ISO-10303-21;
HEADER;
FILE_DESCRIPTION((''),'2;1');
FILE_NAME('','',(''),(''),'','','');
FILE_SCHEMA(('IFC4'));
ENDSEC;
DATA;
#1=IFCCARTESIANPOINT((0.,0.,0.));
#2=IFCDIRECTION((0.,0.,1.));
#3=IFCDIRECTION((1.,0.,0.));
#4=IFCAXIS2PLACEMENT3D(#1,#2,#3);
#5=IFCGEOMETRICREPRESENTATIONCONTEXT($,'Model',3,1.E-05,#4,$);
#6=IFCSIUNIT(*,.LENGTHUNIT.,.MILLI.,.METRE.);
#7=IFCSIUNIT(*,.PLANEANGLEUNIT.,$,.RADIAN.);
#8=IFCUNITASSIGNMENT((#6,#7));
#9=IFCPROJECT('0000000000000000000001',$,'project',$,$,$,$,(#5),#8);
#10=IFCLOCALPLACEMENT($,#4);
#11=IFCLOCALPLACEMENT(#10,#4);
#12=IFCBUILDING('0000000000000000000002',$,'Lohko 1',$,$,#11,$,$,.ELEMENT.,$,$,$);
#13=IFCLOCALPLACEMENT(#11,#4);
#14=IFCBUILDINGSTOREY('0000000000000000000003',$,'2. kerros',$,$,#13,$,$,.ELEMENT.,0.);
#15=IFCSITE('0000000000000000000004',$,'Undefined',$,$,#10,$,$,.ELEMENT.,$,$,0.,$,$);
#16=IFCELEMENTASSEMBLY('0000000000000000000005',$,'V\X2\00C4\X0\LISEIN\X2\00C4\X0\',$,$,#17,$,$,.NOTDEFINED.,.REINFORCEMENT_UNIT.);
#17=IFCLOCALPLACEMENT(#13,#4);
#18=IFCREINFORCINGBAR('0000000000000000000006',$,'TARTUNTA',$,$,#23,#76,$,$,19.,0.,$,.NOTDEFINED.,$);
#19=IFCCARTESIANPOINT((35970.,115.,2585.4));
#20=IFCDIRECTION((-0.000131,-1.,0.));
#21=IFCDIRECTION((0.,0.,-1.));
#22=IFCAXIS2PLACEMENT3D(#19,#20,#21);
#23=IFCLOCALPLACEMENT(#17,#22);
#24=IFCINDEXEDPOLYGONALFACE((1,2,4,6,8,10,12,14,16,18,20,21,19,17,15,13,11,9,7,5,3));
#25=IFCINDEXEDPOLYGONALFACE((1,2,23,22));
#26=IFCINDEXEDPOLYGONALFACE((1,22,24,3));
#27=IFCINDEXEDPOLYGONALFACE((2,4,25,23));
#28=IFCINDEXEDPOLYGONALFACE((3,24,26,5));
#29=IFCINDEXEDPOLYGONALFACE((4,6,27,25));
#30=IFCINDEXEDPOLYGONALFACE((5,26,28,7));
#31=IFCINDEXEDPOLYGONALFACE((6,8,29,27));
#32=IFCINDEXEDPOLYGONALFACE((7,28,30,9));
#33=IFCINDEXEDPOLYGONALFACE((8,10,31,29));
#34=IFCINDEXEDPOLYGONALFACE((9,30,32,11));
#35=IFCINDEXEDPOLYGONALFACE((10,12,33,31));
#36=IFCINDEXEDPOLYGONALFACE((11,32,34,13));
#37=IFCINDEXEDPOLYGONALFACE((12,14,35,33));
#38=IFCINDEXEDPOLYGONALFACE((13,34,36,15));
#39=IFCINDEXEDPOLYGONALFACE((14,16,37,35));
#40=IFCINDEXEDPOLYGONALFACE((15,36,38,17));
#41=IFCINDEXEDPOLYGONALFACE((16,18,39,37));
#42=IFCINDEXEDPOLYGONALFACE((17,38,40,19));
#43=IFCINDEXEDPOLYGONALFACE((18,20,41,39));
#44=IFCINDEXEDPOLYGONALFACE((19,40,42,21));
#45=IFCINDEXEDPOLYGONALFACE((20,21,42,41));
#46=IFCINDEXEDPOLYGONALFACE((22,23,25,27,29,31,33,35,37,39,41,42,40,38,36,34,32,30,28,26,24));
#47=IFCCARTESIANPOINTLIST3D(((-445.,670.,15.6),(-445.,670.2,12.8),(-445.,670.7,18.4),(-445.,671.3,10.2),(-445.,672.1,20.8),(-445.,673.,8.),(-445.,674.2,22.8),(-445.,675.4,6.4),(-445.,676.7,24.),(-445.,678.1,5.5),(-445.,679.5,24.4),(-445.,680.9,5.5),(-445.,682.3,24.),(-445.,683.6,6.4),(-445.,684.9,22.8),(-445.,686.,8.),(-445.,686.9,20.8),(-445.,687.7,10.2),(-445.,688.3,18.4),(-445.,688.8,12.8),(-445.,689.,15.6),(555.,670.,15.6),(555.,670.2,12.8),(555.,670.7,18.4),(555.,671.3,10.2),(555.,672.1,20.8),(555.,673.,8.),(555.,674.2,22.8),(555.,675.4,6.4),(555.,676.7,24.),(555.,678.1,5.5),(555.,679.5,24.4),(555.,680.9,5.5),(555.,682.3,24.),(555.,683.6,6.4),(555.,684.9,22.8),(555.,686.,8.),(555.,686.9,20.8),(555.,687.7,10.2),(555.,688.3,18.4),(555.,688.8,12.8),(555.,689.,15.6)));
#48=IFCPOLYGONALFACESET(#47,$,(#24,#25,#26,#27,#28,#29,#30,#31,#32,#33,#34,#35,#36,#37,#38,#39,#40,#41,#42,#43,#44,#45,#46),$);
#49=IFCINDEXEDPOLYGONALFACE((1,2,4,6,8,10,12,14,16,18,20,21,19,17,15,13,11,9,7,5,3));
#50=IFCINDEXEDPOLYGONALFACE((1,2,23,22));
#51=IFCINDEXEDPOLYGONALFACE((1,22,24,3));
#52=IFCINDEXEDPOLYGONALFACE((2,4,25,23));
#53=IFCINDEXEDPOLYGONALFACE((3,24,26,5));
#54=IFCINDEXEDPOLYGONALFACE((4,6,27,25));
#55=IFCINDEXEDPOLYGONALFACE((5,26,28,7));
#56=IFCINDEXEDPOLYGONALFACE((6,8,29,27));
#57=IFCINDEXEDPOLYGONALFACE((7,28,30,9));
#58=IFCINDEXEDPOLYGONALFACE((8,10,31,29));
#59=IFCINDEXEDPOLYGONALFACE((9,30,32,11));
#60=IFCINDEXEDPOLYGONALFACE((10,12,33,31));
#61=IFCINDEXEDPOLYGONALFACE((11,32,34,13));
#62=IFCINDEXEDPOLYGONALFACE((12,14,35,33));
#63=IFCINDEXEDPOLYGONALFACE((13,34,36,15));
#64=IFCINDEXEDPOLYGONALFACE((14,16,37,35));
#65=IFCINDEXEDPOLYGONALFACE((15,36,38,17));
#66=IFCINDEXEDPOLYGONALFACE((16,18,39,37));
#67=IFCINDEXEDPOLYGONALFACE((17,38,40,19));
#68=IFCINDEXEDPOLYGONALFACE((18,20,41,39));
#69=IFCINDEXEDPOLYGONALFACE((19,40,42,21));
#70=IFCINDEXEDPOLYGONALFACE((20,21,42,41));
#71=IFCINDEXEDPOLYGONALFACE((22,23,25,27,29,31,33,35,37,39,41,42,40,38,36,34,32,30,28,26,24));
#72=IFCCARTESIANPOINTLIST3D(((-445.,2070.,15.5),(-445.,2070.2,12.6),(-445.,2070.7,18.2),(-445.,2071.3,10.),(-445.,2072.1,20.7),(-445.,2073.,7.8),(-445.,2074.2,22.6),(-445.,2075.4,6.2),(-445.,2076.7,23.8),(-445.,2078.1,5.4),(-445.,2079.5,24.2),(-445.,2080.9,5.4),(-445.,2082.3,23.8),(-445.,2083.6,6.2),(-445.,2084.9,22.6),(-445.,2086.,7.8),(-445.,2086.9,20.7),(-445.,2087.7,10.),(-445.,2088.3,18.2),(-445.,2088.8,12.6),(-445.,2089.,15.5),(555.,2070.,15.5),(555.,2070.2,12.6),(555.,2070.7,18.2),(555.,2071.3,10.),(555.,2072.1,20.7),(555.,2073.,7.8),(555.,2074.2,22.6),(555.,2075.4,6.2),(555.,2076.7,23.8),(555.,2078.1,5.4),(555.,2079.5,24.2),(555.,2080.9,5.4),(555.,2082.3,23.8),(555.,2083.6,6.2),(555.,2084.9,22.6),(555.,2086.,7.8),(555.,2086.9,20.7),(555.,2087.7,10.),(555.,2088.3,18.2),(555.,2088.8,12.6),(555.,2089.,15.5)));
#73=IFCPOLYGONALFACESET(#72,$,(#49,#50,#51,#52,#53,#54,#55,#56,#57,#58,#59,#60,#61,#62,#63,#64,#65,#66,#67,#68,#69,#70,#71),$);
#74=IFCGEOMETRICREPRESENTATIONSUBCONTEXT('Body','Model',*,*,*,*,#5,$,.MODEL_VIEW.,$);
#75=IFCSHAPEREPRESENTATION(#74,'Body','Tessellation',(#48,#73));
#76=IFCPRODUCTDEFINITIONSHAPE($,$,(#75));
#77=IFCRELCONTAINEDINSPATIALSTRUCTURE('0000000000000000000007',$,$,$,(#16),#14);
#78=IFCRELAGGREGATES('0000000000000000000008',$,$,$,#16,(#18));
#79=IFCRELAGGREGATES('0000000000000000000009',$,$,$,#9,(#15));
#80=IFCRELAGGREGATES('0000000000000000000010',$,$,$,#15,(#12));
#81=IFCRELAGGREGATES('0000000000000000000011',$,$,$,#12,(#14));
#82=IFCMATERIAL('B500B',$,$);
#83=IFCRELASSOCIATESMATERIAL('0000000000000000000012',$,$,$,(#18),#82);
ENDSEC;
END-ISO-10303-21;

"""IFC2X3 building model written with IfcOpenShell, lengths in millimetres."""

from ifc_helpers import new_model, entity, si_unit, frame, origin_with_axes, place, context, subcontext, project, spatial, source, transform, mapped, material, element, aggregate, save


model = new_model("IFC2X3")

# Units and contexts
model_context = context("Model", 3, precision=1e-05, world=origin_with_axes())
body_context = subcontext(model_context, "Body", "Model", "MODEL_VIEW")
ifc_project = project(units=[si_unit("LENGTHUNIT", "METRE", prefix="MILLI"), si_unit("PLANEANGLEUNIT", "RADIAN")], contexts=[model_context])

# Site, building, storey
site_placement = place(None, origin_with_axes())
site = spatial("IfcSite", under=ifc_project, at=site_placement, Name="Undefined", CompositionType="ELEMENT", RefElevation=0.0)
building_placement = place(site_placement, origin_with_axes())
building = spatial("IfcBuilding", under=site, at=building_placement, Name="Lohko 1", CompositionType="ELEMENT")
storey_placement = place(building_placement, origin_with_axes())
storey = spatial("IfcBuildingStorey", under=building, at=storey_placement, Name="2. kerros", CompositionType="ELEMENT", Elevation=0.0)

# Element assembly, reinforcing bar
assembly_placement = place(storey_placement, origin_with_axes())
assembly = element("IfcElementAssembly", 1, at=assembly_placement, inside=storey, Name="VÄLISEINÄ", AssemblyPlace="NOTDEFINED", PredefinedType="REINFORCEMENT_UNIT")
ifc_material = material(Name="B500B")
shared_shape_1 = source(origin_with_axes(), body_context, "Body", "AdvancedSweptSolid", [
    entity("IfcSweptDiskSolid", entity("IfcTrimmedCurve", entity("IfcLine", entity("IfcCartesianPoint", [0.0, 0.0, 0.0]), entity("IfcVector", entity("IfcDirection", [1.0, 0.0, 0.0]), 1.0)), [entity("IfcParameterValue", 0.0)], [entity("IfcParameterValue", 1000.0)], True, "PARAMETER"), 9.5, None, 0.0, 1000.0),
])
shared_shape_2 = source(origin_with_axes(), body_context, "Body", "AdvancedSweptSolid", [
    entity("IfcSweptDiskSolid", entity("IfcTrimmedCurve", entity("IfcLine", entity("IfcCartesianPoint", [0.0, 0.0, 0.0]), entity("IfcVector", entity("IfcDirection", [1.0, 0.0, 0.0]), 1.0)), [entity("IfcParameterValue", 0.0)], [entity("IfcParameterValue", 1000.0)], True, "PARAMETER"), 9.5, None, 0.0, 1000.0),
])
reinforcing_bar_1_placement = place(assembly_placement, frame((35970.0, 115.0, 2585.4), z_axis=(-0.000131, -1.0, 0.0), x_axis=(0.0, 0.0, -1.0)))
reinforcing_bar_1 = element("IfcReinforcingBar", 2, at=reinforcing_bar_1_placement, material=ifc_material, Name="TARTUNTA", BarRole="NOTDEFINED", CrossSectionArea=0.0, NominalDiameter=19.0, context=body_context, shape_type="MappedRepresentation", body=[
    mapped(shared_shape_1, transform((-445.0, 679.5, 14.9))),
    mapped(shared_shape_2, transform((-445.0, 2079.5, 14.7))),
])
aggregate(assembly, [reinforcing_bar_1])

save(model, "model.ifc")
